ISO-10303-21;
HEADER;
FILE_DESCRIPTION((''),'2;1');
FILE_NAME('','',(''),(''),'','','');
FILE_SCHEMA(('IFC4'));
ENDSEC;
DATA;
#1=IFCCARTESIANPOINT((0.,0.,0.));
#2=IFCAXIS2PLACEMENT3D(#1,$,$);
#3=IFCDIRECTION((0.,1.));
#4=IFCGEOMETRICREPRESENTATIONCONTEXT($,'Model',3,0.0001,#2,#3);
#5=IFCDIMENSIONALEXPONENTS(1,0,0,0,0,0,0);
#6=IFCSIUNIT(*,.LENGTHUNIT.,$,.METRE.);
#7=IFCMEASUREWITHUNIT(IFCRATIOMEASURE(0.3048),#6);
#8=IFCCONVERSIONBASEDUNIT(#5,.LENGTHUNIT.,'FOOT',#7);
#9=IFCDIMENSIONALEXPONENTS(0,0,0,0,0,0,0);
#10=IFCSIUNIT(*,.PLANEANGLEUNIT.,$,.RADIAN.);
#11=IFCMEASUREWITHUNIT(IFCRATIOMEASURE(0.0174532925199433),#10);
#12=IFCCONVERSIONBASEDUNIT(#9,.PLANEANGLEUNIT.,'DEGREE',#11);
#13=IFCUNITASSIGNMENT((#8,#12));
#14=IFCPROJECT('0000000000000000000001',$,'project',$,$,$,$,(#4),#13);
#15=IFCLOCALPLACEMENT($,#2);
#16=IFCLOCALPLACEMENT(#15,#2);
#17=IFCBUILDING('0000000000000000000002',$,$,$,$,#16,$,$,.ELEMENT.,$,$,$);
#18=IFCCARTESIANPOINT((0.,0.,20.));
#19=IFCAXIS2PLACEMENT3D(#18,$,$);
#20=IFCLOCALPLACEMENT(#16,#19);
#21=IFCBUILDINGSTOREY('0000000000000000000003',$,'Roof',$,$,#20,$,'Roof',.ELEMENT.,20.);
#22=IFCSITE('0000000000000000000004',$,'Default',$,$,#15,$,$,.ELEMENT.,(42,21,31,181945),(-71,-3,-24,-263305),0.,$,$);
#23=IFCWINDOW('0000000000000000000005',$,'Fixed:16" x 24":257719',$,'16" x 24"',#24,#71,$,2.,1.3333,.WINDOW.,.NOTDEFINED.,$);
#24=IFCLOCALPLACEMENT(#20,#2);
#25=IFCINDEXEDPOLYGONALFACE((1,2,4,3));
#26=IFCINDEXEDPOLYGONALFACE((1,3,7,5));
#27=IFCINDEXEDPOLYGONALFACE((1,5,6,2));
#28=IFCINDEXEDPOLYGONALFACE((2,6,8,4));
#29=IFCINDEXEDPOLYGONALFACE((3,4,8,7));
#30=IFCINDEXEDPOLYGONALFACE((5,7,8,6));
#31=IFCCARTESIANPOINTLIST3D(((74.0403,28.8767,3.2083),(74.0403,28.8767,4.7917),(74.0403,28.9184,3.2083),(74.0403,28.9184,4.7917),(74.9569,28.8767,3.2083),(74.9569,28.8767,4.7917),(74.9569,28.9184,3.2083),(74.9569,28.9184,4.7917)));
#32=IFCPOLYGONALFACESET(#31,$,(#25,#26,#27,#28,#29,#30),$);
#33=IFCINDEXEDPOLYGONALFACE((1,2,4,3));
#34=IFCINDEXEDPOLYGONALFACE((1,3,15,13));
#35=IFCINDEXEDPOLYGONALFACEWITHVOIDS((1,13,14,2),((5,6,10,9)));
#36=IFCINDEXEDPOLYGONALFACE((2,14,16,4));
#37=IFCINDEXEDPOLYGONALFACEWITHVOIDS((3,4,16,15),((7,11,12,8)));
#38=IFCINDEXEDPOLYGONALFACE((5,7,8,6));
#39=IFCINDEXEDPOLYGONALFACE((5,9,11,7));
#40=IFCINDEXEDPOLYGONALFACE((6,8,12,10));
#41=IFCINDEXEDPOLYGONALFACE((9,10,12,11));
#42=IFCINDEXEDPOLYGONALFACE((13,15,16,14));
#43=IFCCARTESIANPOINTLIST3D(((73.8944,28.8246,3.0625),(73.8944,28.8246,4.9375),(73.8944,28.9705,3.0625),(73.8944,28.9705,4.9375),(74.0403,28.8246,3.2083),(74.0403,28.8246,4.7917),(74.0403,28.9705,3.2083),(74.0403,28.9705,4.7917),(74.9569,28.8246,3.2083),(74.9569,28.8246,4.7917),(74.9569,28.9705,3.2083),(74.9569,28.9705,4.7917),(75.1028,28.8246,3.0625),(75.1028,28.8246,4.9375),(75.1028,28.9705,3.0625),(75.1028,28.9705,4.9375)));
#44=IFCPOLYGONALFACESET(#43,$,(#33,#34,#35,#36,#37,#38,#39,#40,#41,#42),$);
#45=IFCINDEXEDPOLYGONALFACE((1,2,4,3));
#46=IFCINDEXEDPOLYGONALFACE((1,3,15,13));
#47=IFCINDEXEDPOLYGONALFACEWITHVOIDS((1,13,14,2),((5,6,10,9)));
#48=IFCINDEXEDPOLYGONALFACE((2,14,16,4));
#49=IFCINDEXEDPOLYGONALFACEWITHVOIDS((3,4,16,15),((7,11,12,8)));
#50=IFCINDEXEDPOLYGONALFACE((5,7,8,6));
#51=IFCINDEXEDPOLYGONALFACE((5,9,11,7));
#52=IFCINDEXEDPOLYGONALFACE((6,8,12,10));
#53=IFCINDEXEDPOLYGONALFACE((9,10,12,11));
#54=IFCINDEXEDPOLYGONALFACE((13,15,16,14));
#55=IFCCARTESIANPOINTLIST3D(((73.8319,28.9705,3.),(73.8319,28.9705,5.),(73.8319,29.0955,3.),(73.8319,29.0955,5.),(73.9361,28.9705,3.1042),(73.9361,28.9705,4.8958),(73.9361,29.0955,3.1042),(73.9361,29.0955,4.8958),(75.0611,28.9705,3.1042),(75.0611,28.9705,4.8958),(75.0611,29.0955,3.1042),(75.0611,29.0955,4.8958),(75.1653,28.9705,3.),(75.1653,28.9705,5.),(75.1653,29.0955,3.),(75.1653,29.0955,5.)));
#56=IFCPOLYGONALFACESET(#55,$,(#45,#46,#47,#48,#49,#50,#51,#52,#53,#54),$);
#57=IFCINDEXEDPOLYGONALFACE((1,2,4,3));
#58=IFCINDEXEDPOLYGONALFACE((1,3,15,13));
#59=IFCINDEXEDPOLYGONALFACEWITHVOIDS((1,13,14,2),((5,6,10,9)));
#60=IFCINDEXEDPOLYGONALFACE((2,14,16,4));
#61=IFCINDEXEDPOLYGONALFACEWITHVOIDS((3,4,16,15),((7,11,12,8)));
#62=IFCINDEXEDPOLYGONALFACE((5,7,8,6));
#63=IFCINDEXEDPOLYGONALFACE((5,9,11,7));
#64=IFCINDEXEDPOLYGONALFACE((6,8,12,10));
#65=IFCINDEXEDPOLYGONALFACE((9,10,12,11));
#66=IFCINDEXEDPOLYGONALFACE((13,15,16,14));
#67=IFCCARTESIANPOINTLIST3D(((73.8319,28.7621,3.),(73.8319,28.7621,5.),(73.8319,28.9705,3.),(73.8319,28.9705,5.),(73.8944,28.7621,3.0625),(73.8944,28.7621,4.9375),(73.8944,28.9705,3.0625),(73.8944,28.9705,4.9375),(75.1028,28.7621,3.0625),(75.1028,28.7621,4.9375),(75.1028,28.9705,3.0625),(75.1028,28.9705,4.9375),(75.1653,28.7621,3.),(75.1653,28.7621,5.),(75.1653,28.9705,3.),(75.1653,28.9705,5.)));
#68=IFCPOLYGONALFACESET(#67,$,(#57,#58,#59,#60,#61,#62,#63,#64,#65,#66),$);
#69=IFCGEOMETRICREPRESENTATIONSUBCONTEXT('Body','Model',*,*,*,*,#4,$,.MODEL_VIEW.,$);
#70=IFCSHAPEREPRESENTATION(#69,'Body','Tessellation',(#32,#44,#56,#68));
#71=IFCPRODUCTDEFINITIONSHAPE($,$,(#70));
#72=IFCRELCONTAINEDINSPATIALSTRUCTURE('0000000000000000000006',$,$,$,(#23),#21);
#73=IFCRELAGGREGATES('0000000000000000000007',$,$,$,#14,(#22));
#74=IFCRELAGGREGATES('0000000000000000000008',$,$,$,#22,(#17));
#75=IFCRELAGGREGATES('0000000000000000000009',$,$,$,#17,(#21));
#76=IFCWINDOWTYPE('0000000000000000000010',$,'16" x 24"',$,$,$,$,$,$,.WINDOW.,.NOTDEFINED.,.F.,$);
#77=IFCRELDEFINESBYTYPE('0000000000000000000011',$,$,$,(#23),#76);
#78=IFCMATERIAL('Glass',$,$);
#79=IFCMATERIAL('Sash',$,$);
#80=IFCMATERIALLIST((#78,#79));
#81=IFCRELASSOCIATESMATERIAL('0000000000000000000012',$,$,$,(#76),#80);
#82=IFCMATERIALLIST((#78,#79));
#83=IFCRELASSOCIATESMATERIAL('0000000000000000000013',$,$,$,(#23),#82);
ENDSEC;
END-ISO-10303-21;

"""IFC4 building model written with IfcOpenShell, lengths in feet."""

from ifc_helpers import new_model, entity, si_unit, converted_unit, direction, frame, origin, origin_2d_with_axis, place, context, subcontext, project, spatial, polyline, rectangle, outline, extrude, source, transform, mapped, material, material_list, type_object, type_shapes, element, save


model = new_model("IFC4")

# Units and contexts
model_context = context("Model", 3, precision=0.0001, world=origin(), true_north=direction((0.0, 1.0)))
body_context = subcontext(model_context, "Body", "Model", "MODEL_VIEW")
ifc_project = project(units=[converted_unit("LENGTHUNIT", "FOOT", entity("IfcRatioMeasure", 0.3048), si_unit("LENGTHUNIT", "METRE"), dimensions=[1, 0, 0, 0, 0, 0, 0]), converted_unit("PLANEANGLEUNIT", "DEGREE", entity("IfcRatioMeasure", 0.0174532925199433), si_unit("PLANEANGLEUNIT", "RADIAN"), dimensions=[0, 0, 0, 0, 0, 0, 0])], contexts=[model_context])

# Site, building, storey
site_placement = place(None, origin())
site = spatial("IfcSite", under=ifc_project, at=site_placement, Name="Default", CompositionType="ELEMENT", RefLatitude=(42, 21, 31, 181945), RefLongitude=(-71, -3, -24, -263305), RefElevation=0.0)
building_placement = place(site_placement, origin())
building = spatial("IfcBuilding", under=site, at=building_placement, CompositionType="ELEMENT")
storey_placement = place(building_placement, frame((0.0, 0.0, 20.0)))
storey = spatial("IfcBuildingStorey", under=building, at=storey_placement, Name="Roof", LongName="Roof", CompositionType="ELEMENT", Elevation=20.0)

# Shared definitions
placement_1 = place(storey_placement, frame((-0.1681, 28.9288, 0.0)))

# Window
ifc_material_1 = material(Name="Glass")
ifc_material_2 = material(Name="Sash")
ifc_material_list_1 = material_list([ifc_material_1, ifc_material_2])
ifc_material_list_2 = material_list([ifc_material_1, ifc_material_2])
window_type = type_object("IfcWindowType", Name="16\" x 24\"", ParameterTakesPrecedence=False, PartitioningType="NOTDEFINED", PredefinedType="WINDOW", material=ifc_material_list_2)
shared_shape = source(origin(), body_context, "Body", "SweptSolid", [
    extrude(rectangle(XDim=0.0417, YDim=0.9167, at=origin_2d_with_axis()), frame((0.6667, 0.1979, 0.2083), z_axis=(0.0, 0.0, 1.0), x_axis=(0.0, 1.0, 0.0)), (0.0, 0.0, 1.0), 1.5833),
    extrude(outline(polyline([(-0.6042, -0.9375), (0.6042, -0.9375), (0.6042, 0.9375), (-0.6042, 0.9375), (-0.6042, -0.9375)]), holes=[polyline([(-0.4583, -0.7917), (-0.4583, 0.7917), (0.4583, 0.7917), (0.4583, -0.7917), (-0.4583, -0.7917)])]), frame((0.6667, 0.125, 1.0), z_axis=(0.0, 1.0, 0.0), x_axis=(1.0, 0.0, 0.0)), (0.0, 0.0, 1.0), 0.1458),
    extrude(outline(polyline([(-0.6667, -1.0), (0.6667, -1.0), (0.6667, 1.0), (-0.6667, 1.0), (-0.6667, -1.0)]), holes=[polyline([(-0.5625, -0.8958), (-0.5625, 0.8958), (0.5625, 0.8958), (0.5625, -0.8958), (-0.5625, -0.8958)])]), frame((0.6667, 0.0, 1.0), z_axis=(0.0, 1.0, 0.0), x_axis=(1.0, 0.0, 0.0)), (0.0, 0.0, 1.0), 0.125),
    extrude(outline(polyline([(-1.0, -0.6667), (1.0, -0.6667), (1.0, 0.6667), (-1.0, 0.6667), (-1.0, -0.6667)]), holes=[polyline([(-0.9375, -0.6042), (-0.9375, 0.6042), (0.9375, 0.6042), (0.9375, -0.6042), (-0.9375, -0.6042)])]), frame((0.6667, 0.125, 1.0), z_axis=(0.0, 1.0, 0.0), x_axis=(0.0, 0.0, -1.0)), (0.0, 0.0, 1.0), 0.2083),
])
type_shapes(window_type, [shared_shape])
placement_2 = place(placement_1, frame((75.3333, 0.1667, 3.0)))
window_placement = place(placement_2, frame((0.0, 0.0, 0.0), z_axis=(0.0, 0.0, 1.0), x_axis=(-1.0, 0.0, 0.0)))
element("IfcWindow", 1, at=window_placement, inside=storey, type_object=window_type, material=ifc_material_list_1, Name="Fixed:16\" x 24\":257719", ObjectType="16\" x 24\"", OverallHeight=2.0, OverallWidth=1.3333, PartitioningType="NOTDEFINED", PredefinedType="WINDOW", context=body_context, shape_type="MappedRepresentation", body=[
    mapped(shared_shape, transform((0.0, 0.0, 0.0), scale=1.0)),
])

save(model, "model.ifc")
